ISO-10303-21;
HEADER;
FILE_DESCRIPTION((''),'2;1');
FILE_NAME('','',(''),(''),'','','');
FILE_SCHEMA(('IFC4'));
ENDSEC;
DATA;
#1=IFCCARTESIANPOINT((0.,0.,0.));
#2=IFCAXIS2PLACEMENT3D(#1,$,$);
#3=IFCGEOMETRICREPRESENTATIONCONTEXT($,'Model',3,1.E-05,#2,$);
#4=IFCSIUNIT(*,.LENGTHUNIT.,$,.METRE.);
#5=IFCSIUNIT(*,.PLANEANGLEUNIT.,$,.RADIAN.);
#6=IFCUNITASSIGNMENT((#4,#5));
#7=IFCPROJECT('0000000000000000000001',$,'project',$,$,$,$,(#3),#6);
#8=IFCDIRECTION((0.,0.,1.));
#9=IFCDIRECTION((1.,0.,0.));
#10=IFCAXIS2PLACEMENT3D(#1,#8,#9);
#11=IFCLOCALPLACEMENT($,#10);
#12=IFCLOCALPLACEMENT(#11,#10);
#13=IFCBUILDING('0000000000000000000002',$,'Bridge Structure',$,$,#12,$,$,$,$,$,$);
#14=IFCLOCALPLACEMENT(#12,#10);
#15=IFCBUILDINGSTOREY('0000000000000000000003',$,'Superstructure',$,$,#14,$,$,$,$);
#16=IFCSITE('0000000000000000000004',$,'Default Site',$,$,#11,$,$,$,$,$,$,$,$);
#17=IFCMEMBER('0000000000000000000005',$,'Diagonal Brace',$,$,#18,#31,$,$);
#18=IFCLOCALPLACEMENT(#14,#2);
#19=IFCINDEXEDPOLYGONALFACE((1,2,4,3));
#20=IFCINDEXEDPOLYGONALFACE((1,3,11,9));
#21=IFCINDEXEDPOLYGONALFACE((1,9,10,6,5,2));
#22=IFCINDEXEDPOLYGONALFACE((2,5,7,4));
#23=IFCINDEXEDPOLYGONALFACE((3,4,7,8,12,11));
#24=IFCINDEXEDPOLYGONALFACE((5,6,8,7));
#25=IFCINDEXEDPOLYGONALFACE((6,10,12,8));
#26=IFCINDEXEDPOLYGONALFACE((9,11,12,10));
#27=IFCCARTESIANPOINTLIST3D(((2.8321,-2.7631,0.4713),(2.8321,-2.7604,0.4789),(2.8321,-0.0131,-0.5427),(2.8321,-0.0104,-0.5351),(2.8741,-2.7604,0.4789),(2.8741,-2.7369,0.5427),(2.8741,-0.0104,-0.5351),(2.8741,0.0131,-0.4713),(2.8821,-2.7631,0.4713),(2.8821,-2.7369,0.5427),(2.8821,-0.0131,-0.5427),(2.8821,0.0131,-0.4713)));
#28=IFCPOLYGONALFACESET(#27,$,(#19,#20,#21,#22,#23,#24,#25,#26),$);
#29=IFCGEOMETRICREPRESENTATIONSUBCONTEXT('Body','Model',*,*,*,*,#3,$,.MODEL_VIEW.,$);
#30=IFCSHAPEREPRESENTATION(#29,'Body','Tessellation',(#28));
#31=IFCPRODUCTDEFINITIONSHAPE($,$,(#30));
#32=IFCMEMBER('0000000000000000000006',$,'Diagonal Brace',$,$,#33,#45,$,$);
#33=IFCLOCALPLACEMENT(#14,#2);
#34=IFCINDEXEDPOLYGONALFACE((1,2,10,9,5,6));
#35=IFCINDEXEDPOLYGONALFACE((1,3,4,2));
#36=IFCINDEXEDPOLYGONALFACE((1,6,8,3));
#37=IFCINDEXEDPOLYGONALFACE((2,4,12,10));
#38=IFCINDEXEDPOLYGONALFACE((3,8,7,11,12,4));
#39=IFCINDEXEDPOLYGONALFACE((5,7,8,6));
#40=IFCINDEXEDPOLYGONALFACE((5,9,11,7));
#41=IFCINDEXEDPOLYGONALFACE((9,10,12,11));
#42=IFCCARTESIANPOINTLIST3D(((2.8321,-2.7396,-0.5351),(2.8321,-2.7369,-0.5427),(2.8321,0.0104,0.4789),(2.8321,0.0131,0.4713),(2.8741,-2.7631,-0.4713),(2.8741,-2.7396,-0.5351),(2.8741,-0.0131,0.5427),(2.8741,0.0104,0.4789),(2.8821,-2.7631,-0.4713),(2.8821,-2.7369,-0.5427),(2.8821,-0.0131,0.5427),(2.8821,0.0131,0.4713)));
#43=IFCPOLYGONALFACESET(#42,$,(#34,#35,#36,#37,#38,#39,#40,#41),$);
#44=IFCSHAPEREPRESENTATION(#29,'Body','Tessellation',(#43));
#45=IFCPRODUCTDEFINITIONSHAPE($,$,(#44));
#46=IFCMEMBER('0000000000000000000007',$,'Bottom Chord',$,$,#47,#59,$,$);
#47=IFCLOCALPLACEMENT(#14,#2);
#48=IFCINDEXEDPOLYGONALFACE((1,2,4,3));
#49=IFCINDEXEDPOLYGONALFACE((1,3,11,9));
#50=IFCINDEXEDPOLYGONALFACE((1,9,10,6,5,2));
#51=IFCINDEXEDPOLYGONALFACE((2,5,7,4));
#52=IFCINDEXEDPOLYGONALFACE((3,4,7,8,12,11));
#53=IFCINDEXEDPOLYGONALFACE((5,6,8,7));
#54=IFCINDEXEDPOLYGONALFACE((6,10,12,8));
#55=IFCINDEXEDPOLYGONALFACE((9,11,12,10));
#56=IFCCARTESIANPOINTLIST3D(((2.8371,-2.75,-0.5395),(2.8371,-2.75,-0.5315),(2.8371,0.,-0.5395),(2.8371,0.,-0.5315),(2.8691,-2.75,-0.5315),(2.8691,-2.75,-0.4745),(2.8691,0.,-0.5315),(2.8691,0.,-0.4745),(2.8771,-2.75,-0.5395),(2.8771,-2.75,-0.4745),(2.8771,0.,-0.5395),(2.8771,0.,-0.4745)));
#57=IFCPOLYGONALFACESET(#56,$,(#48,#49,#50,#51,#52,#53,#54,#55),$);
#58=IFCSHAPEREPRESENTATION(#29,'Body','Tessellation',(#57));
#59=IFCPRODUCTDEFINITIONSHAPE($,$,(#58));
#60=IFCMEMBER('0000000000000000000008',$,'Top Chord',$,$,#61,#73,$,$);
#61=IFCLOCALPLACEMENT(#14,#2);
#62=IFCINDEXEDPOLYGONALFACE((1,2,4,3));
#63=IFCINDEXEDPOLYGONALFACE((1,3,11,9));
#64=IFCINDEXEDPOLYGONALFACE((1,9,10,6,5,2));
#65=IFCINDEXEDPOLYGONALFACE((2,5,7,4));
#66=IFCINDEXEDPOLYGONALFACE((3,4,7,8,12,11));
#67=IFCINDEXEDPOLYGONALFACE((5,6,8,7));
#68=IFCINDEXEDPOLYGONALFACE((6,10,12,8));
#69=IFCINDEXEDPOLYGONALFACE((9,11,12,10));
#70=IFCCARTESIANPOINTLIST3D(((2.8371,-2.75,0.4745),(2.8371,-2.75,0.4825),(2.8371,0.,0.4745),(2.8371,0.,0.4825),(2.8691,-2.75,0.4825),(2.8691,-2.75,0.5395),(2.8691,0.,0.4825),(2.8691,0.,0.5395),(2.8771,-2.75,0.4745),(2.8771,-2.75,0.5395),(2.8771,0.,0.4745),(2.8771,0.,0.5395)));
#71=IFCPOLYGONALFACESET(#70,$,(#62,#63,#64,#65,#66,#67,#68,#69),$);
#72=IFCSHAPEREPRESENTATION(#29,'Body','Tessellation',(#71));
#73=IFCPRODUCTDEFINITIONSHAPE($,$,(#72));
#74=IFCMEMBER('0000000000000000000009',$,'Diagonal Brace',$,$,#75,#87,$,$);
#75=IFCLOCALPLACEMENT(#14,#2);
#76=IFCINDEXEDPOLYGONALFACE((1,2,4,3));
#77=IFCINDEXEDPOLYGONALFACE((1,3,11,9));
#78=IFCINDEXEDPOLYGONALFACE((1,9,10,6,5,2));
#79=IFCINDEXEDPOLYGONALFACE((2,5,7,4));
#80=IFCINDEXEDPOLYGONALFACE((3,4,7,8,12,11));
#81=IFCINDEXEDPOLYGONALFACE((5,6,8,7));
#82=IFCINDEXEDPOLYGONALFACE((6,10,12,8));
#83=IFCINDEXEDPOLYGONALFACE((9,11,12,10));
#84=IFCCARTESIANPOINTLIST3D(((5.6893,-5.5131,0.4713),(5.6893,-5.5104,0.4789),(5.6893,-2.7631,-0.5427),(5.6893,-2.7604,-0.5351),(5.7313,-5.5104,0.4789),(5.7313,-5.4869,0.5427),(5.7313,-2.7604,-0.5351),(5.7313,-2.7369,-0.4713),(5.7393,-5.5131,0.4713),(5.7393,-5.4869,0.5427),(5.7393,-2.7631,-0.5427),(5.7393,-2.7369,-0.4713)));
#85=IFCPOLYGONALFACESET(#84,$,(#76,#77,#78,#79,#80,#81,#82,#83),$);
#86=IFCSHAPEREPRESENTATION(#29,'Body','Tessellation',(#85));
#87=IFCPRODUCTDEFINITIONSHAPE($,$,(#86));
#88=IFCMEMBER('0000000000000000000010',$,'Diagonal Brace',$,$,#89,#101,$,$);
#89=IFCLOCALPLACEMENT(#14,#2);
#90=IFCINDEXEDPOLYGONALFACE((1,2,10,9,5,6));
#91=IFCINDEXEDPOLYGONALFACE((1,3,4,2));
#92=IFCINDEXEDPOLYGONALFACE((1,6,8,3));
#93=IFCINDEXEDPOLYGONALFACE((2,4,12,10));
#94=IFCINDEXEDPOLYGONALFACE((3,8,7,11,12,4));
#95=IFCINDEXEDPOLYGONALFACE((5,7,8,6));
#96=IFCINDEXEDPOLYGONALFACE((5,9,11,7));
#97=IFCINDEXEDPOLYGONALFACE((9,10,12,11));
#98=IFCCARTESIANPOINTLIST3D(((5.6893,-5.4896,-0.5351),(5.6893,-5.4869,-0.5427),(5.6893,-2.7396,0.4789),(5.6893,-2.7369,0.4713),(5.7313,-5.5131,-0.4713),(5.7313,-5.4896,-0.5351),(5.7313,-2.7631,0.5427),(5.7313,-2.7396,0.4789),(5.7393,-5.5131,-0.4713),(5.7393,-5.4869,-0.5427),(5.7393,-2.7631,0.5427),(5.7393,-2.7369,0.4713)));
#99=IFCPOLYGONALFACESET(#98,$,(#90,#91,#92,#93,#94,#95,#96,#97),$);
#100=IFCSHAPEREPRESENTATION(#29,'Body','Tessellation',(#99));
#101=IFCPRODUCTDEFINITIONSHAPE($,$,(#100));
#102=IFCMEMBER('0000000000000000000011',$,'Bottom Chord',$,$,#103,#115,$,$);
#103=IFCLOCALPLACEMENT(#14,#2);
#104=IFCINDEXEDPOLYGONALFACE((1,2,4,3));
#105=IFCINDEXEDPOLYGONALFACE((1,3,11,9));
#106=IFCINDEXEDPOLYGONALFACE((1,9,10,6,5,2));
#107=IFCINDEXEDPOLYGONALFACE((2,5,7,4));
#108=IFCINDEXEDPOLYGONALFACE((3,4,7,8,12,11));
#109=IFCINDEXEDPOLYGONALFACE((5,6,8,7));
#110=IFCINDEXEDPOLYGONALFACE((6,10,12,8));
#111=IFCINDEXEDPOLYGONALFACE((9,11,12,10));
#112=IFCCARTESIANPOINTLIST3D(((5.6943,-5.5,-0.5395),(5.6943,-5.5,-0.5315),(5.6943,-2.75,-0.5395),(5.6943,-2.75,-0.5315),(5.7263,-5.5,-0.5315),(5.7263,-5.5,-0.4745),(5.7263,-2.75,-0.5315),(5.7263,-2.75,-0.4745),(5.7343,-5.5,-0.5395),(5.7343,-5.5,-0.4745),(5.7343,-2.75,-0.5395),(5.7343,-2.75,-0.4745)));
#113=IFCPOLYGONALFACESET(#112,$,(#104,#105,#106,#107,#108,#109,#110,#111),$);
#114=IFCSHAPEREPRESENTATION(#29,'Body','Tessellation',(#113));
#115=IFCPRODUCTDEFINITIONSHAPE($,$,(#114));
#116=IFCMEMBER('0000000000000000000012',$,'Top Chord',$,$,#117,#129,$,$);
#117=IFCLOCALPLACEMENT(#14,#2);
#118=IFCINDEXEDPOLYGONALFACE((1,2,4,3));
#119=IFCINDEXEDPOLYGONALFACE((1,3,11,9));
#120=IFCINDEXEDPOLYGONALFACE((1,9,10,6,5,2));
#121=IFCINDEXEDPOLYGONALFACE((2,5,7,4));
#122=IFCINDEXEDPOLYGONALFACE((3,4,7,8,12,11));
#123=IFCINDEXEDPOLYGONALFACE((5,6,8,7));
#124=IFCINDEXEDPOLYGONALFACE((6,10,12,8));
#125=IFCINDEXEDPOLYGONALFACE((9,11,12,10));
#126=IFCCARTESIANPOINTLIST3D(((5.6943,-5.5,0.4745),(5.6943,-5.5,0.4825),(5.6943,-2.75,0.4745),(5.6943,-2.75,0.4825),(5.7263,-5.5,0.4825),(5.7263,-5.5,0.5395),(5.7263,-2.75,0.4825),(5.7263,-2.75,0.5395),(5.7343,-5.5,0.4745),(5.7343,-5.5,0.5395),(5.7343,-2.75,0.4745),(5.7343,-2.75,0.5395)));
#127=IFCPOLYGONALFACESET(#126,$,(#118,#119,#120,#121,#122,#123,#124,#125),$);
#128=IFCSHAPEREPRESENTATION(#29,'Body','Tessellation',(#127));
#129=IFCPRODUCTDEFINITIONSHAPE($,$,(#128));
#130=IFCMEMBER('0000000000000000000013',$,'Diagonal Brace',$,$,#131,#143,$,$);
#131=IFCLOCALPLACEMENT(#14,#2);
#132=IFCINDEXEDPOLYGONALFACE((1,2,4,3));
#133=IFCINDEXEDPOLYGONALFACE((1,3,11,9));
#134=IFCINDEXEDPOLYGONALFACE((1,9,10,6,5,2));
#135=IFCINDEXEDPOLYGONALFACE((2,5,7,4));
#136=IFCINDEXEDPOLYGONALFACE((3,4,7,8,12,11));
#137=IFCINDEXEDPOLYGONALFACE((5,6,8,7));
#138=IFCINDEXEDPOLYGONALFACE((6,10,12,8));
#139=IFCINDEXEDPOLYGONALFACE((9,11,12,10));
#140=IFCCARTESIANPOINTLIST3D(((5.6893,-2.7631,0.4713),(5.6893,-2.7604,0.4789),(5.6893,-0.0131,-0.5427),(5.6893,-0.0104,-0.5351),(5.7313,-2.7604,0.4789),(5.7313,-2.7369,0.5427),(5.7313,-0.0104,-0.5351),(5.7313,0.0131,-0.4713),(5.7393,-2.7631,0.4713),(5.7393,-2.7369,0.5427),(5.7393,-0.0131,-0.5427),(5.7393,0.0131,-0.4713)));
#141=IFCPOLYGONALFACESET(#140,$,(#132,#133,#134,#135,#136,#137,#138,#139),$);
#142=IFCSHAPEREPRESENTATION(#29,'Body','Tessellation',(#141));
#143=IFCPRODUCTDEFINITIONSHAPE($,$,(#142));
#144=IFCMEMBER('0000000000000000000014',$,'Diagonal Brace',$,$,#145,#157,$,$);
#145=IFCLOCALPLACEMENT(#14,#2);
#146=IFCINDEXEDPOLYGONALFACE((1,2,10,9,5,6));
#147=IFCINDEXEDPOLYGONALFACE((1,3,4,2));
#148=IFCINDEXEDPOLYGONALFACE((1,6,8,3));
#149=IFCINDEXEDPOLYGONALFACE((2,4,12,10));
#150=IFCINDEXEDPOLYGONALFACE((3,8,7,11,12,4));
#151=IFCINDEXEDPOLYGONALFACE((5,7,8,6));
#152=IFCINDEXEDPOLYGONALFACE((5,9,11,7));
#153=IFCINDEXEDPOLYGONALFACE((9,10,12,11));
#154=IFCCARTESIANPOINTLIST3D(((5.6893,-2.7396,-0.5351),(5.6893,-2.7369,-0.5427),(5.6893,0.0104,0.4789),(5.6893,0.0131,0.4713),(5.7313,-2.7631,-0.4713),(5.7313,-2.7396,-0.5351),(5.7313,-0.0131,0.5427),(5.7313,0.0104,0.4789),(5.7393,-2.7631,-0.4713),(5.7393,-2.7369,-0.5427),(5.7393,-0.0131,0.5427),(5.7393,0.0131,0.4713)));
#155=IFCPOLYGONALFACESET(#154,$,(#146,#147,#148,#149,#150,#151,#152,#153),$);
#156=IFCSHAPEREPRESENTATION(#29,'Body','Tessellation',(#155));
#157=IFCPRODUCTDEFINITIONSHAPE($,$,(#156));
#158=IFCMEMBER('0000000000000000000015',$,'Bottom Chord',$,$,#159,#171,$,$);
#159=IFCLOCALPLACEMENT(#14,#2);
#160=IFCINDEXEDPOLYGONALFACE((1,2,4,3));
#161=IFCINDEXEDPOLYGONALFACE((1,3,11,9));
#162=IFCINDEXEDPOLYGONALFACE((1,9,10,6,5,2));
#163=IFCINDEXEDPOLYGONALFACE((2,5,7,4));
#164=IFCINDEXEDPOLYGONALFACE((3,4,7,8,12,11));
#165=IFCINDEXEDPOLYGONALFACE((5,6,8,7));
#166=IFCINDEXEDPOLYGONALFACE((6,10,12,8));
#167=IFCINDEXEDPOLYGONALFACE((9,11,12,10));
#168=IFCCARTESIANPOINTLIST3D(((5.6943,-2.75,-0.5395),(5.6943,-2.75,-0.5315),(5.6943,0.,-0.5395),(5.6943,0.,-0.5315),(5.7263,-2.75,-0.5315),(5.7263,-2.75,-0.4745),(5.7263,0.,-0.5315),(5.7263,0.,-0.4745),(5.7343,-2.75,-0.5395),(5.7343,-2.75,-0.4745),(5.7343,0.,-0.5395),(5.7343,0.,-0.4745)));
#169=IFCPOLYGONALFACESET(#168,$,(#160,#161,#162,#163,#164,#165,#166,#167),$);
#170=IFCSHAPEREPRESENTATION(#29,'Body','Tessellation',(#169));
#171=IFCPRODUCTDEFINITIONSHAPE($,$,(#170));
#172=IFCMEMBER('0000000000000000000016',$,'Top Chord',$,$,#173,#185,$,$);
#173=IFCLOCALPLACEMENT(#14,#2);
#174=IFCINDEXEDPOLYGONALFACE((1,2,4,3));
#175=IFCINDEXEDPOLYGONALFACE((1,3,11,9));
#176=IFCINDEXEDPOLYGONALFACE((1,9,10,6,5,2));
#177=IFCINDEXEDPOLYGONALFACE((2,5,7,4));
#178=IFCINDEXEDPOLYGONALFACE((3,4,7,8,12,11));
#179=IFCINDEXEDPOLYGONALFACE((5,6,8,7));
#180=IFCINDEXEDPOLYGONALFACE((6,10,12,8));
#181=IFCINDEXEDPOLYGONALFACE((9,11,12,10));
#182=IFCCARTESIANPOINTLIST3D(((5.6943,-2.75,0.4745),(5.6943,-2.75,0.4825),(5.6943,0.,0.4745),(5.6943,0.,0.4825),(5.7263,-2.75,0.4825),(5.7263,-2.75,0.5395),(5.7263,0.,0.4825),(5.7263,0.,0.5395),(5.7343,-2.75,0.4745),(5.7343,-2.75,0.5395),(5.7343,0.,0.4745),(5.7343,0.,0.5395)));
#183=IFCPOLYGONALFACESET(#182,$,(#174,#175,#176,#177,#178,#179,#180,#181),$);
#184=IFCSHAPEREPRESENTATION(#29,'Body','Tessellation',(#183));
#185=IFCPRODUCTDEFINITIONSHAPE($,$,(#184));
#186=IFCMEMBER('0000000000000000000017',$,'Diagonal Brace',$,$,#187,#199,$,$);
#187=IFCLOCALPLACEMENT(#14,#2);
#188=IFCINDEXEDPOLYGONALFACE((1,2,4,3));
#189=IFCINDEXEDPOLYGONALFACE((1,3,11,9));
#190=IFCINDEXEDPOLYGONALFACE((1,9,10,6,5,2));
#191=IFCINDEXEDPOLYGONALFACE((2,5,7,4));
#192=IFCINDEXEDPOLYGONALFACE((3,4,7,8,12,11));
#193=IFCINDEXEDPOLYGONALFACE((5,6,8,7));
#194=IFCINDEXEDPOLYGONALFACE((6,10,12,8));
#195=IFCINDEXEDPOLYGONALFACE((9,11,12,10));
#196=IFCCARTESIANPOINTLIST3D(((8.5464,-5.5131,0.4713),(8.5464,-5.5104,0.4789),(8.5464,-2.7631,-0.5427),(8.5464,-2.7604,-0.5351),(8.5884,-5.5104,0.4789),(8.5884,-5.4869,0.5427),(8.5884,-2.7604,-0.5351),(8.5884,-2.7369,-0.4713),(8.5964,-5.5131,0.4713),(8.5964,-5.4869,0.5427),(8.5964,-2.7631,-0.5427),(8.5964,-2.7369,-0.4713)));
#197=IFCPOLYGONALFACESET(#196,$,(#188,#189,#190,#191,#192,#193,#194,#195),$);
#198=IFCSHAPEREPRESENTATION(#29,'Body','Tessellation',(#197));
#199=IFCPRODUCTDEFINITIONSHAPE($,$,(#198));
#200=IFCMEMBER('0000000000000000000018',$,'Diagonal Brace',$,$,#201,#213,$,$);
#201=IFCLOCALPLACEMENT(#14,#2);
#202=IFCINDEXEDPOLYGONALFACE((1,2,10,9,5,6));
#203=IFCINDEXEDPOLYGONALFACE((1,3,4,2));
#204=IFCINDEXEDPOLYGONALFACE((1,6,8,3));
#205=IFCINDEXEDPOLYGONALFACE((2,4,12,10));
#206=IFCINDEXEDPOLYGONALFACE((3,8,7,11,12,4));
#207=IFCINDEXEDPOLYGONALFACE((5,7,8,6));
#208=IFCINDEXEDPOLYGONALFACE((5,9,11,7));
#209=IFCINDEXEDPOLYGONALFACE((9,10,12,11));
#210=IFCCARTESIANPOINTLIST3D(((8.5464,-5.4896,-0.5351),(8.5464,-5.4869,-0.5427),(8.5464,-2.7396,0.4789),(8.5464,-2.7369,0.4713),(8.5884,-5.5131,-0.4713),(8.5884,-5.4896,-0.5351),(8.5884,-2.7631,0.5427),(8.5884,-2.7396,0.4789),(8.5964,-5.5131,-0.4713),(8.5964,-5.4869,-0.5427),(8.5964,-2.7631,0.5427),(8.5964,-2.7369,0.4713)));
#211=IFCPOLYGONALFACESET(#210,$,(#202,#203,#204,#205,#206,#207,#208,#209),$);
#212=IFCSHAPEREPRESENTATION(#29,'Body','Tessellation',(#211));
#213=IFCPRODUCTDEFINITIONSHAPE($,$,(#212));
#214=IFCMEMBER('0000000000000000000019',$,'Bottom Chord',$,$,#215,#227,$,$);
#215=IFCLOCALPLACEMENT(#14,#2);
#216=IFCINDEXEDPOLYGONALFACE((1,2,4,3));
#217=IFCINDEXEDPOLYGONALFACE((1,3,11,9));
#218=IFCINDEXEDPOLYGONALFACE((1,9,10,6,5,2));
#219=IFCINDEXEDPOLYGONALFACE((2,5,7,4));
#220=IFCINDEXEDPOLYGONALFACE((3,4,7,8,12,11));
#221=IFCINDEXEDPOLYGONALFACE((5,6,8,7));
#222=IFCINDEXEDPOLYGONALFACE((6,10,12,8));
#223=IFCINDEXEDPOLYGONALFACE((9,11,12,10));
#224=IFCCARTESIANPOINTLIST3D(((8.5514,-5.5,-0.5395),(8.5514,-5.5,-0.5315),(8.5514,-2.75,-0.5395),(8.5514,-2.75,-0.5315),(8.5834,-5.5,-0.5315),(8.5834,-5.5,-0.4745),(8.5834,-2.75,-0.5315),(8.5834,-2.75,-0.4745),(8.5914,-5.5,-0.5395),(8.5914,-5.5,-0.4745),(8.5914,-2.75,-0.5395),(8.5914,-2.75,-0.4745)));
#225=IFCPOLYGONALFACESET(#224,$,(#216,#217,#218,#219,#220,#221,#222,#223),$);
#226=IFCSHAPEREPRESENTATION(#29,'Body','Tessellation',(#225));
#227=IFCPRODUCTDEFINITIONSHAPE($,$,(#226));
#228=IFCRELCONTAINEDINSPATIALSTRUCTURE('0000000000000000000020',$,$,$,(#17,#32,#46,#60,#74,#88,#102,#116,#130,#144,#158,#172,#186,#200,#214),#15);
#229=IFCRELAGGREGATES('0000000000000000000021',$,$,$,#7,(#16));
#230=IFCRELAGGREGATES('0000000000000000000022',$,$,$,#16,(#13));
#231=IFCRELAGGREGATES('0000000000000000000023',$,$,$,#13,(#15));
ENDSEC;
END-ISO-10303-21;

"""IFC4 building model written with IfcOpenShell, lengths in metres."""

from ifc_helpers import new_model, si_unit, frame, origin, origin_with_axes, origin_2d_with_axis, place, context, subcontext, project, spatial, l_section, extrude, element, save


model = new_model("IFC4")

# Units and contexts
model_context = context("Model", 3, precision=1e-05, world=origin())
body_context = subcontext(model_context, "Body", "Model", "MODEL_VIEW")
ifc_project = project(units=[si_unit("LENGTHUNIT", "METRE"), si_unit("PLANEANGLEUNIT", "RADIAN")], contexts=[model_context])

# Site, building, storey
site_placement = place(None, origin_with_axes())
site = spatial("IfcSite", under=ifc_project, at=site_placement, Name="Default Site")
building_placement = place(site_placement, origin_with_axes())
building = spatial("IfcBuilding", under=site, at=building_placement, Name="Bridge Structure")
storey_placement = place(building_placement, origin_with_axes())
storey = spatial("IfcBuildingStorey", under=building, at=storey_placement, Name="Superstructure")

# Members
for number, where, z_axis, x_axis, name in (
    (1, (2.8571, -2.75, 0.507), (0.0, 0.93825, -0.345958), (-1.0, 0.0, 0.0), "Diagonal Brace"),
    (2, (2.8571, -2.75, -0.507), (0.0, 0.93825, 0.345958), (-1.0, 0.0, 0.0), "Diagonal Brace"),
):
    element("IfcMember", number, at=place(storey_placement, frame(where, z_axis=z_axis, x_axis=x_axis)), inside=storey, Name=name, context=body_context, shape_type="SweptSolid", body=[
        extrude(l_section(Depth=0.076, Width=0.05, Thickness=0.008, at=origin_2d_with_axis()), origin_with_axes(), (0.0, 0.0, 1.0), 2.931),
    ])
for number, where, z_axis, x_axis, name in (
    (3, (2.8571, -2.75, -0.507), (0.0, 1.0, 0.0), (-1.0, 0.0, 0.0), "Bottom Chord"),
    (4, (2.8571, -2.75, 0.507), (0.0, 1.0, 0.0), (-1.0, 0.0, 0.0), "Top Chord"),
):
    element("IfcMember", number, at=place(storey_placement, frame(where, z_axis=z_axis, x_axis=x_axis)), inside=storey, Name=name, context=body_context, shape_type="SweptSolid", body=[
        extrude(l_section(Depth=0.065, Width=0.04, Thickness=0.008, at=origin_2d_with_axis()), origin_with_axes(), (0.0, 0.0, 1.0), 2.75),
    ])
for number, where, z_axis, x_axis, name in (
    (5, (5.7143, -5.5, 0.507), (0.0, 0.93825, -0.345958), (-1.0, 0.0, 0.0), "Diagonal Brace"),
    (6, (5.7143, -5.5, -0.507), (0.0, 0.93825, 0.345958), (-1.0, 0.0, 0.0), "Diagonal Brace"),
):
    element("IfcMember", number, at=place(storey_placement, frame(where, z_axis=z_axis, x_axis=x_axis)), inside=storey, Name=name, context=body_context, shape_type="SweptSolid", body=[
        extrude(l_section(Depth=0.076, Width=0.05, Thickness=0.008, at=origin_2d_with_axis()), origin_with_axes(), (0.0, 0.0, 1.0), 2.931),
    ])
for number, where, z_axis, x_axis, name in (
    (7, (5.7143, -5.5, -0.507), (0.0, 1.0, 0.0), (-1.0, 0.0, 0.0), "Bottom Chord"),
    (8, (5.7143, -5.5, 0.507), (0.0, 1.0, 0.0), (-1.0, 0.0, 0.0), "Top Chord"),
):
    element("IfcMember", number, at=place(storey_placement, frame(where, z_axis=z_axis, x_axis=x_axis)), inside=storey, Name=name, context=body_context, shape_type="SweptSolid", body=[
        extrude(l_section(Depth=0.065, Width=0.04, Thickness=0.008, at=origin_2d_with_axis()), origin_with_axes(), (0.0, 0.0, 1.0), 2.75),
    ])
for number, where, z_axis, x_axis, name in (
    (9, (5.7143, -2.75, 0.507), (0.0, 0.93825, -0.345958), (-1.0, 0.0, 0.0), "Diagonal Brace"),
    (10, (5.7143, -2.75, -0.507), (0.0, 0.93825, 0.345958), (-1.0, 0.0, 0.0), "Diagonal Brace"),
):
    element("IfcMember", number, at=place(storey_placement, frame(where, z_axis=z_axis, x_axis=x_axis)), inside=storey, Name=name, context=body_context, shape_type="SweptSolid", body=[
        extrude(l_section(Depth=0.076, Width=0.05, Thickness=0.008, at=origin_2d_with_axis()), origin_with_axes(), (0.0, 0.0, 1.0), 2.931),
    ])
for number, where, z_axis, x_axis, name in (
    (11, (5.7143, -2.75, -0.507), (0.0, 1.0, 0.0), (-1.0, 0.0, 0.0), "Bottom Chord"),
    (12, (5.7143, -2.75, 0.507), (0.0, 1.0, 0.0), (-1.0, 0.0, 0.0), "Top Chord"),
):
    element("IfcMember", number, at=place(storey_placement, frame(where, z_axis=z_axis, x_axis=x_axis)), inside=storey, Name=name, context=body_context, shape_type="SweptSolid", body=[
        extrude(l_section(Depth=0.065, Width=0.04, Thickness=0.008, at=origin_2d_with_axis()), origin_with_axes(), (0.0, 0.0, 1.0), 2.75),
    ])
for number, where, z_axis, x_axis, name in (
    (13, (8.5714, -5.5, 0.507), (0.0, 0.93825, -0.345958), (-1.0, 0.0, 0.0), "Diagonal Brace"),
    (14, (8.5714, -5.5, -0.507), (0.0, 0.93825, 0.345958), (-1.0, 0.0, 0.0), "Diagonal Brace"),
):
    element("IfcMember", number, at=place(storey_placement, frame(where, z_axis=z_axis, x_axis=x_axis)), inside=storey, Name=name, context=body_context, shape_type="SweptSolid", body=[
        extrude(l_section(Depth=0.076, Width=0.05, Thickness=0.008, at=origin_2d_with_axis()), origin_with_axes(), (0.0, 0.0, 1.0), 2.931),
    ])
for number, where, z_axis, x_axis, name in (
    (15, (8.5714, -5.5, -0.507), (0.0, 1.0, 0.0), (-1.0, 0.0, 0.0), "Bottom Chord"),
):
    element("IfcMember", number, at=place(storey_placement, frame(where, z_axis=z_axis, x_axis=x_axis)), inside=storey, Name=name, context=body_context, shape_type="SweptSolid", body=[
        extrude(l_section(Depth=0.065, Width=0.04, Thickness=0.008, at=origin_2d_with_axis()), origin_with_axes(), (0.0, 0.0, 1.0), 2.75),
    ])

save(model, "model.ifc")
